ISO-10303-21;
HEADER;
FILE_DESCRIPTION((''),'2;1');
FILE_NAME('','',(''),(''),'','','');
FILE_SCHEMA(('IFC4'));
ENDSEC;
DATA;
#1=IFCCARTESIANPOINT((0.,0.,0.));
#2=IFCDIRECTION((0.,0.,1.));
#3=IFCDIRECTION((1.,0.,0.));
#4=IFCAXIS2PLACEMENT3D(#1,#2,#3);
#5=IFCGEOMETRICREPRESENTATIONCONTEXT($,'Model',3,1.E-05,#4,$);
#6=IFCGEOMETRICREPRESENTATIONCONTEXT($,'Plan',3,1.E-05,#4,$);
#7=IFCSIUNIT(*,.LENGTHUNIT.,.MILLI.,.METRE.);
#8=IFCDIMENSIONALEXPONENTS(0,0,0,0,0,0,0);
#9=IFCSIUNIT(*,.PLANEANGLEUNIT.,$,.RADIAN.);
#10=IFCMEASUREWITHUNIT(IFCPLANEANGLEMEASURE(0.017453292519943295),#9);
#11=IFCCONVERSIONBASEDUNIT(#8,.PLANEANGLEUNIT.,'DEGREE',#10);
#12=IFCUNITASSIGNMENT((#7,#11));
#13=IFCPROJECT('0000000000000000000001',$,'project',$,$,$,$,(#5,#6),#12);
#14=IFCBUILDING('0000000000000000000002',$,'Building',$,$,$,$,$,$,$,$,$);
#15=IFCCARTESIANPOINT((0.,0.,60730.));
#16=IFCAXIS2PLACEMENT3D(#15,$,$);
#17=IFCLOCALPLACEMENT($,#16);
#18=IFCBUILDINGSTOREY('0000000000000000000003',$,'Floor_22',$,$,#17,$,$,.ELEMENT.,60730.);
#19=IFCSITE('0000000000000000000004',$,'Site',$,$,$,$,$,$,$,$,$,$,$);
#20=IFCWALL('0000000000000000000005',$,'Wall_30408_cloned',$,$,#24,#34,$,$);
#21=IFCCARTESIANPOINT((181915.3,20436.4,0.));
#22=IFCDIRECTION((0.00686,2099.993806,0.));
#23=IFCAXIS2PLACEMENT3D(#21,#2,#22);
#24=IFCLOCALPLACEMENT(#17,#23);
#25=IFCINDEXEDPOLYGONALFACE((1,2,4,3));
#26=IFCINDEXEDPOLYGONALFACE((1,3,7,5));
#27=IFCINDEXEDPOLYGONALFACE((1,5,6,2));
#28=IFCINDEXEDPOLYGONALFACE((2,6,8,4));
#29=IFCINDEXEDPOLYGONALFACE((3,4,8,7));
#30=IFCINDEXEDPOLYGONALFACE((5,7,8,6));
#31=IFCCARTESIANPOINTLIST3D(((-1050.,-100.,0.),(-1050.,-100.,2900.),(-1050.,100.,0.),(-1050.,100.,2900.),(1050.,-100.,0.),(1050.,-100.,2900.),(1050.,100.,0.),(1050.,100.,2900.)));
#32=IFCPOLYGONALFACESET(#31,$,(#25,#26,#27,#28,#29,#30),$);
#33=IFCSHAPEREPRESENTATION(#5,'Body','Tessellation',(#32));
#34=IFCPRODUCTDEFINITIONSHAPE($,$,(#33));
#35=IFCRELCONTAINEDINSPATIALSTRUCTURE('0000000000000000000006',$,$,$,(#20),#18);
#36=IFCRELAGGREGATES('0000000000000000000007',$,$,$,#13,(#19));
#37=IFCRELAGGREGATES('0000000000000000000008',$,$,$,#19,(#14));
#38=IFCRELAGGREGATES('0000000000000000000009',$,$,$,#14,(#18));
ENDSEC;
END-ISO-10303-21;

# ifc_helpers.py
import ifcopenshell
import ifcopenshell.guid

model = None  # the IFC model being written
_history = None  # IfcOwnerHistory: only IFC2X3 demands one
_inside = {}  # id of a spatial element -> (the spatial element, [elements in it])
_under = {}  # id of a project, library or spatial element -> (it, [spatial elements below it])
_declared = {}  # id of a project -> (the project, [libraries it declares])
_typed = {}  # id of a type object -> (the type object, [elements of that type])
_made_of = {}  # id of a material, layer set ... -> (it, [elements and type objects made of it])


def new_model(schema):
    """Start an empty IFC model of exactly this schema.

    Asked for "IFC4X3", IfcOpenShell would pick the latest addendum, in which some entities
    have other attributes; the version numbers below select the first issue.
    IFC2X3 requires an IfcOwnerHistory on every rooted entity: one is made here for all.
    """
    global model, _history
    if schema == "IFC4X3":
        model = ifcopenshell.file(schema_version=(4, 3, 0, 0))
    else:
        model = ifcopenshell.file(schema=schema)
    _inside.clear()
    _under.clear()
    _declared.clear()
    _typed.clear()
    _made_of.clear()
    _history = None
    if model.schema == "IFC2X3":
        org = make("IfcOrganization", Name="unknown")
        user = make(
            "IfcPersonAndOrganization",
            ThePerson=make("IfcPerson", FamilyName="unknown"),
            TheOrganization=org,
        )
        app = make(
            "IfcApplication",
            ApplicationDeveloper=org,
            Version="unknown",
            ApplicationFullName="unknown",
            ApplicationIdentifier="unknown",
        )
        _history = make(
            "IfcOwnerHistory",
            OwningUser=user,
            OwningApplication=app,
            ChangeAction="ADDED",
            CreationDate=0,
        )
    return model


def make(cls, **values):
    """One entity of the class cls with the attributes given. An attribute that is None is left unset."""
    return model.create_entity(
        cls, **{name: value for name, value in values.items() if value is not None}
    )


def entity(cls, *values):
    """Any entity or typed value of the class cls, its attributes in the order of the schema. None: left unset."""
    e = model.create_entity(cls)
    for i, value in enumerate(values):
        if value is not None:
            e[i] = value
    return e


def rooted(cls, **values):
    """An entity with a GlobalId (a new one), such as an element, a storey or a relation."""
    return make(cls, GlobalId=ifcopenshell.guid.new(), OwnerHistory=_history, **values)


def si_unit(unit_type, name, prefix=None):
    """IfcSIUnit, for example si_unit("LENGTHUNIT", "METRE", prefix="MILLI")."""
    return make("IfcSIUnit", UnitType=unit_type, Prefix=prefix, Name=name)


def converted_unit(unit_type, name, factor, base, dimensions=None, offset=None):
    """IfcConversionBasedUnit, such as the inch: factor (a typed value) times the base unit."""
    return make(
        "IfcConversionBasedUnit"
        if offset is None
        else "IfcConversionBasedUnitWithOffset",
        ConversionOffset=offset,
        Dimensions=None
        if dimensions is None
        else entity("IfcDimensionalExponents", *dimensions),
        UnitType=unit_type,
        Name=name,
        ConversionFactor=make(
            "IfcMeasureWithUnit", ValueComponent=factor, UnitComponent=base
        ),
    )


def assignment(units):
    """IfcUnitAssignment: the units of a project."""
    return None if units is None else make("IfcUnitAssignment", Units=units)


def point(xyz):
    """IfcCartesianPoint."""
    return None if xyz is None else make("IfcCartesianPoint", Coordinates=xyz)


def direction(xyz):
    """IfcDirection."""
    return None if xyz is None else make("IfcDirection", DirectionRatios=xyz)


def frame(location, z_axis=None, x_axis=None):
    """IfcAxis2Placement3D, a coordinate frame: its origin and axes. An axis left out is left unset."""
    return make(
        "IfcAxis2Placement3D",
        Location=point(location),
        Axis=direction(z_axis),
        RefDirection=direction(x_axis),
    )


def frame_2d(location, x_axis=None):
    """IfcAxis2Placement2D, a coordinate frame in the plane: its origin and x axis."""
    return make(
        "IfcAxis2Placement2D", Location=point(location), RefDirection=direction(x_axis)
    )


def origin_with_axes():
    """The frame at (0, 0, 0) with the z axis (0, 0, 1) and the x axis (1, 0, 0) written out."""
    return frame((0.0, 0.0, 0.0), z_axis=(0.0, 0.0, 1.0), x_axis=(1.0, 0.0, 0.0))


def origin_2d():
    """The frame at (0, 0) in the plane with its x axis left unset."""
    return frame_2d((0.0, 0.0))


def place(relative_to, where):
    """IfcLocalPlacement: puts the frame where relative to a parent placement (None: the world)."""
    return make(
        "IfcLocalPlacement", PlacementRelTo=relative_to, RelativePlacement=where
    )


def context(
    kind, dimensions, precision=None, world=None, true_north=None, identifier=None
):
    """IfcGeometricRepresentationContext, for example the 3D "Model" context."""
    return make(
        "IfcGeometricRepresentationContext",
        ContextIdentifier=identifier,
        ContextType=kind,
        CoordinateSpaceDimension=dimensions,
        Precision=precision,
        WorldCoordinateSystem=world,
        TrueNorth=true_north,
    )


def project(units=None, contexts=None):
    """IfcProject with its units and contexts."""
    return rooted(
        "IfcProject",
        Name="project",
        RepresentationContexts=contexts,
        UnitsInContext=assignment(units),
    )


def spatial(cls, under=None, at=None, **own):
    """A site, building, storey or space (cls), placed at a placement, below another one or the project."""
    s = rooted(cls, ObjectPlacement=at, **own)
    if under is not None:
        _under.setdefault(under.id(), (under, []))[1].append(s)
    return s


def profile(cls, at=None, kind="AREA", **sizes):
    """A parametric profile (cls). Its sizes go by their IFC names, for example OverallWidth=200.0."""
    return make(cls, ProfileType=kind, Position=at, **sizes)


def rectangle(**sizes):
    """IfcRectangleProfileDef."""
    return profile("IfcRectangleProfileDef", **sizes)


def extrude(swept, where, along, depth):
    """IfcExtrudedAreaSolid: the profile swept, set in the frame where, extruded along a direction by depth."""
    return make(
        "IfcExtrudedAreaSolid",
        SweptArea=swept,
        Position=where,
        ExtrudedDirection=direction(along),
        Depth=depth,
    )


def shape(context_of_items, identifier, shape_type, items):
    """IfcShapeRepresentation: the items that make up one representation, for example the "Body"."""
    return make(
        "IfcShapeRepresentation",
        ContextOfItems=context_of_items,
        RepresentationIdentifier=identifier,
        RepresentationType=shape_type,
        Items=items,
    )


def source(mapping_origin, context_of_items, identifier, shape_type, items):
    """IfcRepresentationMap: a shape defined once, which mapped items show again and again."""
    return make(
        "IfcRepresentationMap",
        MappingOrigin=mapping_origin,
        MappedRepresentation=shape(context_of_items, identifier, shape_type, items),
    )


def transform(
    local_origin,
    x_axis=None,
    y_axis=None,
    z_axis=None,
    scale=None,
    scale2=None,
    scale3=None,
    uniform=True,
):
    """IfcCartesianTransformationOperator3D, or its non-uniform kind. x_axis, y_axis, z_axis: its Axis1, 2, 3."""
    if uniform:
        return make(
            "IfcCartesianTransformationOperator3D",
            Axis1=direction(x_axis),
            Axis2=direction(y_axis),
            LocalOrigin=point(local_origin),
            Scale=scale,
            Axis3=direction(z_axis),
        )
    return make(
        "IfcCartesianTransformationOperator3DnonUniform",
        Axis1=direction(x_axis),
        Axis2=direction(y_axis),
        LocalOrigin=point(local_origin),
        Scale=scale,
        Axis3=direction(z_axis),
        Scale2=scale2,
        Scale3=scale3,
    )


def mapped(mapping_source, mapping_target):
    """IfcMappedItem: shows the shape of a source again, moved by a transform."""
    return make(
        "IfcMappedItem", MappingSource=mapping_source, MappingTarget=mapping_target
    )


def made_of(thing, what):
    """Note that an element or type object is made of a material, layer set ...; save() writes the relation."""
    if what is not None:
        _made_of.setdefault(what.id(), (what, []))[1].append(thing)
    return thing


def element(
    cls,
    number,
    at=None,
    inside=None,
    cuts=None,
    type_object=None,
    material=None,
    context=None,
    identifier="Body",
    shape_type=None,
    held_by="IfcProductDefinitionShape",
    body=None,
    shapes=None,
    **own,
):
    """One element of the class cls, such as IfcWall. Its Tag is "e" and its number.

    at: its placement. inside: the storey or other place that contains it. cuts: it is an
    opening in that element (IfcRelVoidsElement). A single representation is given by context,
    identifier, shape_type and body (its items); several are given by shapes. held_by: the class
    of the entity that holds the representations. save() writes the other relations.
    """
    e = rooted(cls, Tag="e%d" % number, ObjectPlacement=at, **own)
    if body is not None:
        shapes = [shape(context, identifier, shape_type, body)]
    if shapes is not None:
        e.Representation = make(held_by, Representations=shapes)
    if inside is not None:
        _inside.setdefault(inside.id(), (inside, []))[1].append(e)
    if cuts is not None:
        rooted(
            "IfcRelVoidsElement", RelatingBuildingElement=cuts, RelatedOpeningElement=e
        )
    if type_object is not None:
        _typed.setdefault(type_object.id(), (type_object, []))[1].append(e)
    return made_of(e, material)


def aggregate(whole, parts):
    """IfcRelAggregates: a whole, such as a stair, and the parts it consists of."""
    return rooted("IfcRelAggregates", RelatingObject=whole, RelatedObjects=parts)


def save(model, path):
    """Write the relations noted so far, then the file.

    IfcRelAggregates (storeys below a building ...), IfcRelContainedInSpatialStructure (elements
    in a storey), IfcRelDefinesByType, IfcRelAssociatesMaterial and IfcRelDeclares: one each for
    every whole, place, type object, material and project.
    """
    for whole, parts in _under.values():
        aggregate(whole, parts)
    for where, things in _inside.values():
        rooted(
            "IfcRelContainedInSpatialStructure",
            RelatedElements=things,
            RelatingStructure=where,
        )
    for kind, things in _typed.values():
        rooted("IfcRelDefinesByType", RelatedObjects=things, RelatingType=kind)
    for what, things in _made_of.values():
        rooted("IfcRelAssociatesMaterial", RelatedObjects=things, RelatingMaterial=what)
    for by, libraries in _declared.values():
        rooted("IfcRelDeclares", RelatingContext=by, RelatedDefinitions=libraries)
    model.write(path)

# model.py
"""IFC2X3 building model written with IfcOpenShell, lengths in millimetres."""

from ifc_helpers import new_model, entity, si_unit, converted_unit, frame, origin_with_axes, origin_2d, place, context, project, spatial, rectangle, extrude, source, transform, mapped, element, save


model = new_model("IFC2X3")

# Units and contexts
model_context = context("Model", 3, precision=1e-05, world=origin_with_axes())
plan_context = context("Plan", 3, precision=1e-05, world=origin_with_axes())
ifc_project = project(units=[si_unit("LENGTHUNIT", "METRE", prefix="MILLI"), converted_unit("PLANEANGLEUNIT", "DEGREE", entity("IfcPlaneAngleMeasure", 0.017453292519943295), si_unit("PLANEANGLEUNIT", "RADIAN"), dimensions=[0, 0, 0, 0, 0, 0, 0])], contexts=[model_context, plan_context])

# Site, building, storey
site = spatial("IfcSite", under=ifc_project, Name="Site")
building = spatial("IfcBuilding", under=site, Name="Building")
storey_placement = place(None, frame((0.0, 0.0, 60730.0)))
storey = spatial("IfcBuildingStorey", under=building, at=storey_placement, Name="Floor_22", CompositionType="ELEMENT", Elevation=60730.0)

# Wall
shared_shape_1 = source(origin_with_axes(), model_context, "Body", "SweptSolid", [
    extrude(rectangle(XDim=2100.0, YDim=200.0, at=origin_2d()), origin_with_axes(), (0.0, 0.0, 1.0), 2900.0),
])
wall_1_placement = place(storey_placement, frame((181915.3, 20436.4, 0.0), z_axis=(0.0, 0.0, 1.0), x_axis=(0.00686, 2099.993806, 0.0)))
element("IfcWall", 1, at=wall_1_placement, inside=storey, Name="Wall_30408_cloned", context=model_context, shape_type="MappedRepresentation", body=[
    mapped(shared_shape_1, transform((0.0, 0.0, 0.0), x_axis=(1.0, 0.0, 0.0), y_axis=(0.0, 1.0, 0.0), z_axis=(0.0, 0.0, 1.0), scale=1.0)),
])

save(model, "model.ifc")
